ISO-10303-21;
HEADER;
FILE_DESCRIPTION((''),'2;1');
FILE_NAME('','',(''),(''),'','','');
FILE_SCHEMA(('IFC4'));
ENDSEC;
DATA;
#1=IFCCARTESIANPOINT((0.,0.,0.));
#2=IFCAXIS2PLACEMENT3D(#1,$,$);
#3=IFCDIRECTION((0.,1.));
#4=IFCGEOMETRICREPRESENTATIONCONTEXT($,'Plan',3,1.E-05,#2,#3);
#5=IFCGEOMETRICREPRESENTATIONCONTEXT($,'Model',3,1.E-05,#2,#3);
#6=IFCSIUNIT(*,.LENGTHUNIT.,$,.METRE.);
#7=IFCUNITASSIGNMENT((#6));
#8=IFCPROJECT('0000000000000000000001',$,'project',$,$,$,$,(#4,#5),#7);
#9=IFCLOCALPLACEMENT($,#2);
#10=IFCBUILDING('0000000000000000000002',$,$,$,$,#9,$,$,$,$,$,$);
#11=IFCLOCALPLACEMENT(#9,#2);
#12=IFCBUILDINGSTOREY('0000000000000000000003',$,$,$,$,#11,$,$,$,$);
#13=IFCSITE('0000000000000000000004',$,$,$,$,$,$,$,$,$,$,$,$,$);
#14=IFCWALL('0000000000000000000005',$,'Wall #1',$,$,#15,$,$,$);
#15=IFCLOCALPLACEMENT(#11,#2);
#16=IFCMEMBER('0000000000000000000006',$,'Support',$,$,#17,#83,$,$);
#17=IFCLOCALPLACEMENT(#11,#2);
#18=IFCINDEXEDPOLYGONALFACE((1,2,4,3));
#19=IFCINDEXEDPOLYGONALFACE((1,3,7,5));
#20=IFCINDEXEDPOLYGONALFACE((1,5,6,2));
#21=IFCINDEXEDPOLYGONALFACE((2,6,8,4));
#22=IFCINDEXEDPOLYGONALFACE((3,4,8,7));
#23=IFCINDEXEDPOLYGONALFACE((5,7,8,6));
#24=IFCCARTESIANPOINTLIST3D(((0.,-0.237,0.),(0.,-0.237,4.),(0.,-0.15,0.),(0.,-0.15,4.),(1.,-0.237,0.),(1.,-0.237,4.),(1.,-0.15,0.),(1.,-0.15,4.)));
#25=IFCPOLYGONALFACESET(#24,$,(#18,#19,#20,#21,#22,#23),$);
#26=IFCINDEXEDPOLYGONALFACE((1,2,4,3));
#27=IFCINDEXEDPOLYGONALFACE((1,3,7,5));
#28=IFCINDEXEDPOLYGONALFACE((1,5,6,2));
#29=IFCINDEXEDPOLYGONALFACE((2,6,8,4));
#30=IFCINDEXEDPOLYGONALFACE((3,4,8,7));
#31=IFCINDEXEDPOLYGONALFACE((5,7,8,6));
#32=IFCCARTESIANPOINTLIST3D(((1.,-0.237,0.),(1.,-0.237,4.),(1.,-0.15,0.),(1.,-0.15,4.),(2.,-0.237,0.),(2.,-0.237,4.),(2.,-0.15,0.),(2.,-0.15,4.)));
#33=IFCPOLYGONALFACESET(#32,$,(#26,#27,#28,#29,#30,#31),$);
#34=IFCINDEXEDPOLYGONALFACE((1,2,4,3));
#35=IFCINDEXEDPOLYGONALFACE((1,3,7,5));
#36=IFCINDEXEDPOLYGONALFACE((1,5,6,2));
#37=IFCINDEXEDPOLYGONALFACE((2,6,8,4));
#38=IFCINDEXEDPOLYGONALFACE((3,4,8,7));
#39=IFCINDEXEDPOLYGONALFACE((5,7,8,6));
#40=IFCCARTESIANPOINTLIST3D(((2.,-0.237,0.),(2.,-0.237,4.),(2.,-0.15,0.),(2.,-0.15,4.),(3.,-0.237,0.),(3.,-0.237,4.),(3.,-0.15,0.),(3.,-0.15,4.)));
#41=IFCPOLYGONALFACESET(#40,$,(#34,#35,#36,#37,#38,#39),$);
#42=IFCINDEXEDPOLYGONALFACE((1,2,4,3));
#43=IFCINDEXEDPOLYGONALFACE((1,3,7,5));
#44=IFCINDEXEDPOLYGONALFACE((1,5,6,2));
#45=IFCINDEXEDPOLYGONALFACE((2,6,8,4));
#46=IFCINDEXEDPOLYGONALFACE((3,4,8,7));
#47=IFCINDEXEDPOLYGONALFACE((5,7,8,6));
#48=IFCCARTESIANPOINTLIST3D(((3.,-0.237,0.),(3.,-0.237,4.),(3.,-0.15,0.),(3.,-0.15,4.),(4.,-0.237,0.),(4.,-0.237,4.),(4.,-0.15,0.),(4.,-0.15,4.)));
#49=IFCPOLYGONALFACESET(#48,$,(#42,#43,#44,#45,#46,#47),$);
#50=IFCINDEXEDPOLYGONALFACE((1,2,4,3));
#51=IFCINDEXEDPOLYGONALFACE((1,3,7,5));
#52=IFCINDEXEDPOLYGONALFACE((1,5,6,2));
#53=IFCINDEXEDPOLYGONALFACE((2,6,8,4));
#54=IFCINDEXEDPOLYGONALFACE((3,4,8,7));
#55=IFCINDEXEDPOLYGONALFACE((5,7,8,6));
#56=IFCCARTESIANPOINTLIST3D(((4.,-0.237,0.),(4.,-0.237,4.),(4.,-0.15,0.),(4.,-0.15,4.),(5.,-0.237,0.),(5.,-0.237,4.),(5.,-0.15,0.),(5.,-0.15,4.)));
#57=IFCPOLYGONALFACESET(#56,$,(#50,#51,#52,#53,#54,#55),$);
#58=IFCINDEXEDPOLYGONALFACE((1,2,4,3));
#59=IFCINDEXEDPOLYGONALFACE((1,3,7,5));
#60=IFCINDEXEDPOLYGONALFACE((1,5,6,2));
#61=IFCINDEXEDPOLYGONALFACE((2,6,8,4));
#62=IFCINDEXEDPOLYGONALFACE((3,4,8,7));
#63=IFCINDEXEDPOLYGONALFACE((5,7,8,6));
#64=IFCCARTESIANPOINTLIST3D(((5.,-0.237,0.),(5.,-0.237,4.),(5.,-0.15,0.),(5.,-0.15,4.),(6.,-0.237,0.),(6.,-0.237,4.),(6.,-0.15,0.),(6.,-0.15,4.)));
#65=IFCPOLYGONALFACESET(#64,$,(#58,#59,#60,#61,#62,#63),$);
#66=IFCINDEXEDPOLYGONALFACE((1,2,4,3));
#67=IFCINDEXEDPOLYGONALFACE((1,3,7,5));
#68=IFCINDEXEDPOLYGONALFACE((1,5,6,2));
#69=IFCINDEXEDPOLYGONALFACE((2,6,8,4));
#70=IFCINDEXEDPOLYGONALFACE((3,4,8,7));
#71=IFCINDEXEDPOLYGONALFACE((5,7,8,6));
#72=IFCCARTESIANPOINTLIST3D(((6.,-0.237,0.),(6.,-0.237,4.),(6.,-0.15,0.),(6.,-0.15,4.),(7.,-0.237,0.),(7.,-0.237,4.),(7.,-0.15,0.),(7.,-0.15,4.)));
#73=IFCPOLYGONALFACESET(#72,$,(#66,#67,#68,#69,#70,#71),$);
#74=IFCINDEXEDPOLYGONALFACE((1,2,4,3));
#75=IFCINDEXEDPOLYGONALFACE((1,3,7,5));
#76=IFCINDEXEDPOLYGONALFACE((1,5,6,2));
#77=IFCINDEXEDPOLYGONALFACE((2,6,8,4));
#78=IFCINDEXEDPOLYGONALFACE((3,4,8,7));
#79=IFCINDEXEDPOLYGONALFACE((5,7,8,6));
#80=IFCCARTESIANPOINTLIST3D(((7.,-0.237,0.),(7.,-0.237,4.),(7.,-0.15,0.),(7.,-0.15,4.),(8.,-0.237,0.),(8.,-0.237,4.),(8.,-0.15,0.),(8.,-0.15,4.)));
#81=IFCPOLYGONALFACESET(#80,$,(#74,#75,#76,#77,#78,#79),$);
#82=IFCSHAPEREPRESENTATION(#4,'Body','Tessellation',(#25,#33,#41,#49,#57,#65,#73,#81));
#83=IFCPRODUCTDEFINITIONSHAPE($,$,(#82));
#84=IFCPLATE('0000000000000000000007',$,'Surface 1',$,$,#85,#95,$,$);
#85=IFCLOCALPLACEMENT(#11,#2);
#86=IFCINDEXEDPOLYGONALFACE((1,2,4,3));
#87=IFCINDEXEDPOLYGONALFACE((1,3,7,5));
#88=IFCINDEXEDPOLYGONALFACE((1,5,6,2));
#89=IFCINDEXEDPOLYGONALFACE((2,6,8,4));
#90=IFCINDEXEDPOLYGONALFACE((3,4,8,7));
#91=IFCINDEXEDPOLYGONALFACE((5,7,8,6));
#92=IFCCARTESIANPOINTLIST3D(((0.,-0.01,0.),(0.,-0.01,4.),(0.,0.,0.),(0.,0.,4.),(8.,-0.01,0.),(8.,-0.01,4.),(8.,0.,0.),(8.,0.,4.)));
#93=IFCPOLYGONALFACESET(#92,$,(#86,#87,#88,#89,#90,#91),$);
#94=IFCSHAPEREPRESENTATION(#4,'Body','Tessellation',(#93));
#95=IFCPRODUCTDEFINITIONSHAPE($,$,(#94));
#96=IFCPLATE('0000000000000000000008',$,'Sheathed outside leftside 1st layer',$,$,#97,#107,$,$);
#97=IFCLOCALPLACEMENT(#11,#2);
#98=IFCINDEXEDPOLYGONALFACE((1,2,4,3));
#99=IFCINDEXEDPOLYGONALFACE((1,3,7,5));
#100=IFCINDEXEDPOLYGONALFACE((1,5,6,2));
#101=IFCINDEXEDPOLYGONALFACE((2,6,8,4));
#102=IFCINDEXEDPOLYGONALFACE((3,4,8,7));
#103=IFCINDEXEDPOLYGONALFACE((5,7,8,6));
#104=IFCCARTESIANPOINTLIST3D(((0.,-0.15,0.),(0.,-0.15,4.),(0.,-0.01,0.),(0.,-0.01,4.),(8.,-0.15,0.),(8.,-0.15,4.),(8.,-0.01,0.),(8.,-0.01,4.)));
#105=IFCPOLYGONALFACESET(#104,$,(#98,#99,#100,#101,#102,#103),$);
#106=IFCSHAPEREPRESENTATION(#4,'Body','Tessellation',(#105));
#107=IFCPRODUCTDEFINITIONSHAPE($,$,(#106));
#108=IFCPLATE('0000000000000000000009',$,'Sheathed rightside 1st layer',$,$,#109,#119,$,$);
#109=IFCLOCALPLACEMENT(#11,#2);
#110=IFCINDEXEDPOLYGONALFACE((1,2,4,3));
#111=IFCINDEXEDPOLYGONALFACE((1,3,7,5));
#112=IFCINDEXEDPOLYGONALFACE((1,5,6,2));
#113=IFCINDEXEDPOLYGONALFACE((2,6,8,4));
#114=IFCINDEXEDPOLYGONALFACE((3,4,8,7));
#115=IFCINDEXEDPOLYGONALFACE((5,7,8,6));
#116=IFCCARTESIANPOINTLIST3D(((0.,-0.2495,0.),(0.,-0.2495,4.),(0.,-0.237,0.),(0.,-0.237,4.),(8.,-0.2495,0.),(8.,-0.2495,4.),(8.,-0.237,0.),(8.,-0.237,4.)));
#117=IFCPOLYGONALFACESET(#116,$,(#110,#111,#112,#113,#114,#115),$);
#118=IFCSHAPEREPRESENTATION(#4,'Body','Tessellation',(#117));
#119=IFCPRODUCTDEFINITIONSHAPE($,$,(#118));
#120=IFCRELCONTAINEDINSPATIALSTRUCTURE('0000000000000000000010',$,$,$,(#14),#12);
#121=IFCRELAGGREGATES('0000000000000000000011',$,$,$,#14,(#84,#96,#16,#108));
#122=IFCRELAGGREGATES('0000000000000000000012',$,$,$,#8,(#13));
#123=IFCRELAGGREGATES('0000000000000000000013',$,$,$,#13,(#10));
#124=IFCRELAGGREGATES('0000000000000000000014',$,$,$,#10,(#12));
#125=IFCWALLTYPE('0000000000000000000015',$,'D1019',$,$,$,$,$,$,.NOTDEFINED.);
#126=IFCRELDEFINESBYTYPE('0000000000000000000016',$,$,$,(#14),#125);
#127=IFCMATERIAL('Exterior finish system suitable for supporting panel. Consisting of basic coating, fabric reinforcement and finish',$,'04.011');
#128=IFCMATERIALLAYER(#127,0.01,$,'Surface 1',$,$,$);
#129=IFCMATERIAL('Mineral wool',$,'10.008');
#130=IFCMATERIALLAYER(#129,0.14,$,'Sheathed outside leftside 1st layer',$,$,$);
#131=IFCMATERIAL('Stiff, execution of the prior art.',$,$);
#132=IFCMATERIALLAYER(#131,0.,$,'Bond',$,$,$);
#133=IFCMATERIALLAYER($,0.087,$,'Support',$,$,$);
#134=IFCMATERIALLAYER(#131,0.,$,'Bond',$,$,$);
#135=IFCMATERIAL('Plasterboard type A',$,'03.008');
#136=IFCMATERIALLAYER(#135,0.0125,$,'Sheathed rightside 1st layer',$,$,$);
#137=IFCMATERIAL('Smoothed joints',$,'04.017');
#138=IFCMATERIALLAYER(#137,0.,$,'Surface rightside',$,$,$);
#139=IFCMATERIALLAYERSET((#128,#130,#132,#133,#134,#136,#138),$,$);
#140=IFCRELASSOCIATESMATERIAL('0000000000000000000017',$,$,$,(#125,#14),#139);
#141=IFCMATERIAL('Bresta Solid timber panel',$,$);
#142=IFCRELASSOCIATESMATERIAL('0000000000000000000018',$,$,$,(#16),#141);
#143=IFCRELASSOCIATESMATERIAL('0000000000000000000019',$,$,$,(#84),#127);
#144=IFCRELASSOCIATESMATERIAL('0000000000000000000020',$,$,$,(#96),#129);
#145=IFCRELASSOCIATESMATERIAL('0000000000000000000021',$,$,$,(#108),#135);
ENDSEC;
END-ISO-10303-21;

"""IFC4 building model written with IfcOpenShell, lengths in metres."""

from ifc_helpers import new_model, si_unit, direction, frame, frame_2d, origin, origin_with_axes, place, context, project, spatial, rectangle, extrude, material, layer, layer_set, type_object, element, aggregate, save


model = new_model("IFC4")

# Units and contexts
plan_context = context("Plan", 3, precision=1e-05, world=origin(), true_north=direction((0.0, 1.0)))
model_context = context("Model", 3, precision=1e-05, world=origin(), true_north=direction((0.0, 1.0)))
ifc_project = project(units=[si_unit("LENGTHUNIT", "METRE")], contexts=[plan_context, model_context])

# Site, building, storey
site = spatial("IfcSite", under=ifc_project)
building_placement = place(None, origin())
building = spatial("IfcBuilding", under=site, at=building_placement)
storey_placement = place(building_placement, origin())
storey = spatial("IfcBuildingStorey", under=building, at=storey_placement)

# Wall, member, plates
ifc_material_1 = material(Name="Exterior finish system suitable for supporting panel. Consisting of basic coating, fabric reinforcement and finish", Category="04.011")
ifc_layer_1 = layer(ifc_material_1, 0.01, Name="Surface 1")
ifc_material_2 = material(Name="Mineral wool", Category="10.008")
ifc_layer_2 = layer(ifc_material_2, 0.14, Name="Sheathed outside leftside 1st layer")
ifc_material_3 = material(Name="Stiff, execution of the prior art.")
ifc_layer_3 = layer(ifc_material_3, 0.0, Name="Bond")
ifc_layer_4 = layer(None, 0.087, Name="Support")
ifc_layer_5 = layer(ifc_material_3, 0.0, Name="Bond")
ifc_material_4 = material(Name="Plasterboard type A", Category="03.008")
ifc_layer_6 = layer(ifc_material_4, 0.0125, Name="Sheathed rightside 1st layer")
ifc_material_5 = material(Name="Smoothed joints", Category="04.017")
ifc_layer_7 = layer(ifc_material_5, 0.0, Name="Surface rightside")
ifc_layer_set = layer_set([ifc_layer_1, ifc_layer_2, ifc_layer_3, ifc_layer_4, ifc_layer_5, ifc_layer_6, ifc_layer_7])
wall_type = type_object("IfcWallType", Name="D1019", PredefinedType="NOTDEFINED", material=ifc_layer_set)
wall_placement = place(None, frame((0.0, 0.0, 0.0), z_axis=(0.0, -1.0, 0.0), x_axis=(1.0, 0.0, 0.0)))
wall = element("IfcWall", 1, at=wall_placement, inside=storey, type_object=wall_type, material=ifc_layer_set, Name="Wall #1")
ifc_material_6 = material(Name="Bresta Solid timber panel")
member_placement = place(wall_placement, origin())
member = element("IfcMember", 2, at=member_placement, material=ifc_material_6, Name="Support", context=plan_context, shape_type="SweptSolid", body=[
    extrude(rectangle(XDim=1.0, YDim=0.087, at=frame_2d((0.5, 0.0435), x_axis=(1.0, 0.0))), frame((0.0, 4.0, 0.15), z_axis=(0.0, -1.0, 0.0), x_axis=(1.0, 0.0, 0.0)), (0.0, 0.0, 1.0), 4.0),
    extrude(rectangle(XDim=1.0, YDim=0.087, at=frame_2d((0.5, 0.0435), x_axis=(1.0, 0.0))), frame((1.0, 4.0, 0.15), z_axis=(0.0, -1.0, 0.0), x_axis=(1.0, 0.0, 0.0)), (0.0, 0.0, 1.0), 4.0),
    extrude(rectangle(XDim=1.0, YDim=0.087, at=frame_2d((0.5, 0.0435), x_axis=(1.0, 0.0))), frame((2.0, 4.0, 0.15), z_axis=(0.0, -1.0, 0.0), x_axis=(1.0, 0.0, 0.0)), (0.0, 0.0, 1.0), 4.0),
    extrude(rectangle(XDim=1.0, YDim=0.087, at=frame_2d((0.5, 0.0435), x_axis=(1.0, 0.0))), frame((3.0, 4.0, 0.15), z_axis=(0.0, -1.0, 0.0), x_axis=(1.0, 0.0, 0.0)), (0.0, 0.0, 1.0), 4.0),
    extrude(rectangle(XDim=1.0, YDim=0.087, at=frame_2d((0.5, 0.0435), x_axis=(1.0, 0.0))), frame((4.0, 4.0, 0.15), z_axis=(0.0, -1.0, 0.0), x_axis=(1.0, 0.0, 0.0)), (0.0, 0.0, 1.0), 4.0),
    extrude(rectangle(XDim=1.0, YDim=0.087, at=frame_2d((0.5, 0.0435), x_axis=(1.0, 0.0))), frame((5.0, 4.0, 0.15), z_axis=(0.0, -1.0, 0.0), x_axis=(1.0, 0.0, 0.0)), (0.0, 0.0, 1.0), 4.0),
    extrude(rectangle(XDim=1.0, YDim=0.087, at=frame_2d((0.5, 0.0435), x_axis=(1.0, 0.0))), frame((6.0, 4.0, 0.15), z_axis=(0.0, -1.0, 0.0), x_axis=(1.0, 0.0, 0.0)), (0.0, 0.0, 1.0), 4.0),
    extrude(rectangle(XDim=1.0, YDim=0.087, at=frame_2d((0.5, 0.0435), x_axis=(1.0, 0.0))), frame((7.0, 4.0, 0.15), z_axis=(0.0, -1.0, 0.0), x_axis=(1.0, 0.0, 0.0)), (0.0, 0.0, 1.0), 4.0),
])
plate_1_placement = place(wall_placement, origin())
plate_1 = element("IfcPlate", 3, at=plate_1_placement, material=ifc_material_1, Name="Surface 1", context=plan_context, shape_type="SweptSolid", body=[
    extrude(rectangle(XDim=8.0, YDim=4.0, at=frame_2d((4.0, 2.0), x_axis=(1.0, 0.0))), origin_with_axes(), (0.0, 0.0, 1.0), 0.01),
])
plate_2_placement = place(wall_placement, origin())
plate_2 = element("IfcPlate", 4, at=plate_2_placement, material=ifc_material_2, Name="Sheathed outside leftside 1st layer", context=plan_context, shape_type="SweptSolid", body=[
    extrude(rectangle(XDim=8.0, YDim=4.0, at=frame_2d((4.0, 2.0), x_axis=(1.0, 0.0))), frame((0.0, 0.0, 0.01), z_axis=(0.0, 0.0, 1.0), x_axis=(1.0, 0.0, 0.0)), (0.0, 0.0, 1.0), 0.14),
])
plate_3_placement = place(wall_placement, origin())
plate_3 = element("IfcPlate", 5, at=plate_3_placement, material=ifc_material_4, Name="Sheathed rightside 1st layer", context=plan_context, shape_type="SweptSolid", body=[
    extrude(rectangle(XDim=8.0, YDim=4.0, at=frame_2d((4.0, 2.0), x_axis=(1.0, 0.0))), frame((0.0, 0.0, 0.237), z_axis=(0.0, 0.0, 1.0), x_axis=(1.0, 0.0, 0.0)), (0.0, 0.0, 1.0), 0.0125),
])
aggregate(wall, [plate_1, plate_2, member, plate_3])

save(model, "model.ifc")
